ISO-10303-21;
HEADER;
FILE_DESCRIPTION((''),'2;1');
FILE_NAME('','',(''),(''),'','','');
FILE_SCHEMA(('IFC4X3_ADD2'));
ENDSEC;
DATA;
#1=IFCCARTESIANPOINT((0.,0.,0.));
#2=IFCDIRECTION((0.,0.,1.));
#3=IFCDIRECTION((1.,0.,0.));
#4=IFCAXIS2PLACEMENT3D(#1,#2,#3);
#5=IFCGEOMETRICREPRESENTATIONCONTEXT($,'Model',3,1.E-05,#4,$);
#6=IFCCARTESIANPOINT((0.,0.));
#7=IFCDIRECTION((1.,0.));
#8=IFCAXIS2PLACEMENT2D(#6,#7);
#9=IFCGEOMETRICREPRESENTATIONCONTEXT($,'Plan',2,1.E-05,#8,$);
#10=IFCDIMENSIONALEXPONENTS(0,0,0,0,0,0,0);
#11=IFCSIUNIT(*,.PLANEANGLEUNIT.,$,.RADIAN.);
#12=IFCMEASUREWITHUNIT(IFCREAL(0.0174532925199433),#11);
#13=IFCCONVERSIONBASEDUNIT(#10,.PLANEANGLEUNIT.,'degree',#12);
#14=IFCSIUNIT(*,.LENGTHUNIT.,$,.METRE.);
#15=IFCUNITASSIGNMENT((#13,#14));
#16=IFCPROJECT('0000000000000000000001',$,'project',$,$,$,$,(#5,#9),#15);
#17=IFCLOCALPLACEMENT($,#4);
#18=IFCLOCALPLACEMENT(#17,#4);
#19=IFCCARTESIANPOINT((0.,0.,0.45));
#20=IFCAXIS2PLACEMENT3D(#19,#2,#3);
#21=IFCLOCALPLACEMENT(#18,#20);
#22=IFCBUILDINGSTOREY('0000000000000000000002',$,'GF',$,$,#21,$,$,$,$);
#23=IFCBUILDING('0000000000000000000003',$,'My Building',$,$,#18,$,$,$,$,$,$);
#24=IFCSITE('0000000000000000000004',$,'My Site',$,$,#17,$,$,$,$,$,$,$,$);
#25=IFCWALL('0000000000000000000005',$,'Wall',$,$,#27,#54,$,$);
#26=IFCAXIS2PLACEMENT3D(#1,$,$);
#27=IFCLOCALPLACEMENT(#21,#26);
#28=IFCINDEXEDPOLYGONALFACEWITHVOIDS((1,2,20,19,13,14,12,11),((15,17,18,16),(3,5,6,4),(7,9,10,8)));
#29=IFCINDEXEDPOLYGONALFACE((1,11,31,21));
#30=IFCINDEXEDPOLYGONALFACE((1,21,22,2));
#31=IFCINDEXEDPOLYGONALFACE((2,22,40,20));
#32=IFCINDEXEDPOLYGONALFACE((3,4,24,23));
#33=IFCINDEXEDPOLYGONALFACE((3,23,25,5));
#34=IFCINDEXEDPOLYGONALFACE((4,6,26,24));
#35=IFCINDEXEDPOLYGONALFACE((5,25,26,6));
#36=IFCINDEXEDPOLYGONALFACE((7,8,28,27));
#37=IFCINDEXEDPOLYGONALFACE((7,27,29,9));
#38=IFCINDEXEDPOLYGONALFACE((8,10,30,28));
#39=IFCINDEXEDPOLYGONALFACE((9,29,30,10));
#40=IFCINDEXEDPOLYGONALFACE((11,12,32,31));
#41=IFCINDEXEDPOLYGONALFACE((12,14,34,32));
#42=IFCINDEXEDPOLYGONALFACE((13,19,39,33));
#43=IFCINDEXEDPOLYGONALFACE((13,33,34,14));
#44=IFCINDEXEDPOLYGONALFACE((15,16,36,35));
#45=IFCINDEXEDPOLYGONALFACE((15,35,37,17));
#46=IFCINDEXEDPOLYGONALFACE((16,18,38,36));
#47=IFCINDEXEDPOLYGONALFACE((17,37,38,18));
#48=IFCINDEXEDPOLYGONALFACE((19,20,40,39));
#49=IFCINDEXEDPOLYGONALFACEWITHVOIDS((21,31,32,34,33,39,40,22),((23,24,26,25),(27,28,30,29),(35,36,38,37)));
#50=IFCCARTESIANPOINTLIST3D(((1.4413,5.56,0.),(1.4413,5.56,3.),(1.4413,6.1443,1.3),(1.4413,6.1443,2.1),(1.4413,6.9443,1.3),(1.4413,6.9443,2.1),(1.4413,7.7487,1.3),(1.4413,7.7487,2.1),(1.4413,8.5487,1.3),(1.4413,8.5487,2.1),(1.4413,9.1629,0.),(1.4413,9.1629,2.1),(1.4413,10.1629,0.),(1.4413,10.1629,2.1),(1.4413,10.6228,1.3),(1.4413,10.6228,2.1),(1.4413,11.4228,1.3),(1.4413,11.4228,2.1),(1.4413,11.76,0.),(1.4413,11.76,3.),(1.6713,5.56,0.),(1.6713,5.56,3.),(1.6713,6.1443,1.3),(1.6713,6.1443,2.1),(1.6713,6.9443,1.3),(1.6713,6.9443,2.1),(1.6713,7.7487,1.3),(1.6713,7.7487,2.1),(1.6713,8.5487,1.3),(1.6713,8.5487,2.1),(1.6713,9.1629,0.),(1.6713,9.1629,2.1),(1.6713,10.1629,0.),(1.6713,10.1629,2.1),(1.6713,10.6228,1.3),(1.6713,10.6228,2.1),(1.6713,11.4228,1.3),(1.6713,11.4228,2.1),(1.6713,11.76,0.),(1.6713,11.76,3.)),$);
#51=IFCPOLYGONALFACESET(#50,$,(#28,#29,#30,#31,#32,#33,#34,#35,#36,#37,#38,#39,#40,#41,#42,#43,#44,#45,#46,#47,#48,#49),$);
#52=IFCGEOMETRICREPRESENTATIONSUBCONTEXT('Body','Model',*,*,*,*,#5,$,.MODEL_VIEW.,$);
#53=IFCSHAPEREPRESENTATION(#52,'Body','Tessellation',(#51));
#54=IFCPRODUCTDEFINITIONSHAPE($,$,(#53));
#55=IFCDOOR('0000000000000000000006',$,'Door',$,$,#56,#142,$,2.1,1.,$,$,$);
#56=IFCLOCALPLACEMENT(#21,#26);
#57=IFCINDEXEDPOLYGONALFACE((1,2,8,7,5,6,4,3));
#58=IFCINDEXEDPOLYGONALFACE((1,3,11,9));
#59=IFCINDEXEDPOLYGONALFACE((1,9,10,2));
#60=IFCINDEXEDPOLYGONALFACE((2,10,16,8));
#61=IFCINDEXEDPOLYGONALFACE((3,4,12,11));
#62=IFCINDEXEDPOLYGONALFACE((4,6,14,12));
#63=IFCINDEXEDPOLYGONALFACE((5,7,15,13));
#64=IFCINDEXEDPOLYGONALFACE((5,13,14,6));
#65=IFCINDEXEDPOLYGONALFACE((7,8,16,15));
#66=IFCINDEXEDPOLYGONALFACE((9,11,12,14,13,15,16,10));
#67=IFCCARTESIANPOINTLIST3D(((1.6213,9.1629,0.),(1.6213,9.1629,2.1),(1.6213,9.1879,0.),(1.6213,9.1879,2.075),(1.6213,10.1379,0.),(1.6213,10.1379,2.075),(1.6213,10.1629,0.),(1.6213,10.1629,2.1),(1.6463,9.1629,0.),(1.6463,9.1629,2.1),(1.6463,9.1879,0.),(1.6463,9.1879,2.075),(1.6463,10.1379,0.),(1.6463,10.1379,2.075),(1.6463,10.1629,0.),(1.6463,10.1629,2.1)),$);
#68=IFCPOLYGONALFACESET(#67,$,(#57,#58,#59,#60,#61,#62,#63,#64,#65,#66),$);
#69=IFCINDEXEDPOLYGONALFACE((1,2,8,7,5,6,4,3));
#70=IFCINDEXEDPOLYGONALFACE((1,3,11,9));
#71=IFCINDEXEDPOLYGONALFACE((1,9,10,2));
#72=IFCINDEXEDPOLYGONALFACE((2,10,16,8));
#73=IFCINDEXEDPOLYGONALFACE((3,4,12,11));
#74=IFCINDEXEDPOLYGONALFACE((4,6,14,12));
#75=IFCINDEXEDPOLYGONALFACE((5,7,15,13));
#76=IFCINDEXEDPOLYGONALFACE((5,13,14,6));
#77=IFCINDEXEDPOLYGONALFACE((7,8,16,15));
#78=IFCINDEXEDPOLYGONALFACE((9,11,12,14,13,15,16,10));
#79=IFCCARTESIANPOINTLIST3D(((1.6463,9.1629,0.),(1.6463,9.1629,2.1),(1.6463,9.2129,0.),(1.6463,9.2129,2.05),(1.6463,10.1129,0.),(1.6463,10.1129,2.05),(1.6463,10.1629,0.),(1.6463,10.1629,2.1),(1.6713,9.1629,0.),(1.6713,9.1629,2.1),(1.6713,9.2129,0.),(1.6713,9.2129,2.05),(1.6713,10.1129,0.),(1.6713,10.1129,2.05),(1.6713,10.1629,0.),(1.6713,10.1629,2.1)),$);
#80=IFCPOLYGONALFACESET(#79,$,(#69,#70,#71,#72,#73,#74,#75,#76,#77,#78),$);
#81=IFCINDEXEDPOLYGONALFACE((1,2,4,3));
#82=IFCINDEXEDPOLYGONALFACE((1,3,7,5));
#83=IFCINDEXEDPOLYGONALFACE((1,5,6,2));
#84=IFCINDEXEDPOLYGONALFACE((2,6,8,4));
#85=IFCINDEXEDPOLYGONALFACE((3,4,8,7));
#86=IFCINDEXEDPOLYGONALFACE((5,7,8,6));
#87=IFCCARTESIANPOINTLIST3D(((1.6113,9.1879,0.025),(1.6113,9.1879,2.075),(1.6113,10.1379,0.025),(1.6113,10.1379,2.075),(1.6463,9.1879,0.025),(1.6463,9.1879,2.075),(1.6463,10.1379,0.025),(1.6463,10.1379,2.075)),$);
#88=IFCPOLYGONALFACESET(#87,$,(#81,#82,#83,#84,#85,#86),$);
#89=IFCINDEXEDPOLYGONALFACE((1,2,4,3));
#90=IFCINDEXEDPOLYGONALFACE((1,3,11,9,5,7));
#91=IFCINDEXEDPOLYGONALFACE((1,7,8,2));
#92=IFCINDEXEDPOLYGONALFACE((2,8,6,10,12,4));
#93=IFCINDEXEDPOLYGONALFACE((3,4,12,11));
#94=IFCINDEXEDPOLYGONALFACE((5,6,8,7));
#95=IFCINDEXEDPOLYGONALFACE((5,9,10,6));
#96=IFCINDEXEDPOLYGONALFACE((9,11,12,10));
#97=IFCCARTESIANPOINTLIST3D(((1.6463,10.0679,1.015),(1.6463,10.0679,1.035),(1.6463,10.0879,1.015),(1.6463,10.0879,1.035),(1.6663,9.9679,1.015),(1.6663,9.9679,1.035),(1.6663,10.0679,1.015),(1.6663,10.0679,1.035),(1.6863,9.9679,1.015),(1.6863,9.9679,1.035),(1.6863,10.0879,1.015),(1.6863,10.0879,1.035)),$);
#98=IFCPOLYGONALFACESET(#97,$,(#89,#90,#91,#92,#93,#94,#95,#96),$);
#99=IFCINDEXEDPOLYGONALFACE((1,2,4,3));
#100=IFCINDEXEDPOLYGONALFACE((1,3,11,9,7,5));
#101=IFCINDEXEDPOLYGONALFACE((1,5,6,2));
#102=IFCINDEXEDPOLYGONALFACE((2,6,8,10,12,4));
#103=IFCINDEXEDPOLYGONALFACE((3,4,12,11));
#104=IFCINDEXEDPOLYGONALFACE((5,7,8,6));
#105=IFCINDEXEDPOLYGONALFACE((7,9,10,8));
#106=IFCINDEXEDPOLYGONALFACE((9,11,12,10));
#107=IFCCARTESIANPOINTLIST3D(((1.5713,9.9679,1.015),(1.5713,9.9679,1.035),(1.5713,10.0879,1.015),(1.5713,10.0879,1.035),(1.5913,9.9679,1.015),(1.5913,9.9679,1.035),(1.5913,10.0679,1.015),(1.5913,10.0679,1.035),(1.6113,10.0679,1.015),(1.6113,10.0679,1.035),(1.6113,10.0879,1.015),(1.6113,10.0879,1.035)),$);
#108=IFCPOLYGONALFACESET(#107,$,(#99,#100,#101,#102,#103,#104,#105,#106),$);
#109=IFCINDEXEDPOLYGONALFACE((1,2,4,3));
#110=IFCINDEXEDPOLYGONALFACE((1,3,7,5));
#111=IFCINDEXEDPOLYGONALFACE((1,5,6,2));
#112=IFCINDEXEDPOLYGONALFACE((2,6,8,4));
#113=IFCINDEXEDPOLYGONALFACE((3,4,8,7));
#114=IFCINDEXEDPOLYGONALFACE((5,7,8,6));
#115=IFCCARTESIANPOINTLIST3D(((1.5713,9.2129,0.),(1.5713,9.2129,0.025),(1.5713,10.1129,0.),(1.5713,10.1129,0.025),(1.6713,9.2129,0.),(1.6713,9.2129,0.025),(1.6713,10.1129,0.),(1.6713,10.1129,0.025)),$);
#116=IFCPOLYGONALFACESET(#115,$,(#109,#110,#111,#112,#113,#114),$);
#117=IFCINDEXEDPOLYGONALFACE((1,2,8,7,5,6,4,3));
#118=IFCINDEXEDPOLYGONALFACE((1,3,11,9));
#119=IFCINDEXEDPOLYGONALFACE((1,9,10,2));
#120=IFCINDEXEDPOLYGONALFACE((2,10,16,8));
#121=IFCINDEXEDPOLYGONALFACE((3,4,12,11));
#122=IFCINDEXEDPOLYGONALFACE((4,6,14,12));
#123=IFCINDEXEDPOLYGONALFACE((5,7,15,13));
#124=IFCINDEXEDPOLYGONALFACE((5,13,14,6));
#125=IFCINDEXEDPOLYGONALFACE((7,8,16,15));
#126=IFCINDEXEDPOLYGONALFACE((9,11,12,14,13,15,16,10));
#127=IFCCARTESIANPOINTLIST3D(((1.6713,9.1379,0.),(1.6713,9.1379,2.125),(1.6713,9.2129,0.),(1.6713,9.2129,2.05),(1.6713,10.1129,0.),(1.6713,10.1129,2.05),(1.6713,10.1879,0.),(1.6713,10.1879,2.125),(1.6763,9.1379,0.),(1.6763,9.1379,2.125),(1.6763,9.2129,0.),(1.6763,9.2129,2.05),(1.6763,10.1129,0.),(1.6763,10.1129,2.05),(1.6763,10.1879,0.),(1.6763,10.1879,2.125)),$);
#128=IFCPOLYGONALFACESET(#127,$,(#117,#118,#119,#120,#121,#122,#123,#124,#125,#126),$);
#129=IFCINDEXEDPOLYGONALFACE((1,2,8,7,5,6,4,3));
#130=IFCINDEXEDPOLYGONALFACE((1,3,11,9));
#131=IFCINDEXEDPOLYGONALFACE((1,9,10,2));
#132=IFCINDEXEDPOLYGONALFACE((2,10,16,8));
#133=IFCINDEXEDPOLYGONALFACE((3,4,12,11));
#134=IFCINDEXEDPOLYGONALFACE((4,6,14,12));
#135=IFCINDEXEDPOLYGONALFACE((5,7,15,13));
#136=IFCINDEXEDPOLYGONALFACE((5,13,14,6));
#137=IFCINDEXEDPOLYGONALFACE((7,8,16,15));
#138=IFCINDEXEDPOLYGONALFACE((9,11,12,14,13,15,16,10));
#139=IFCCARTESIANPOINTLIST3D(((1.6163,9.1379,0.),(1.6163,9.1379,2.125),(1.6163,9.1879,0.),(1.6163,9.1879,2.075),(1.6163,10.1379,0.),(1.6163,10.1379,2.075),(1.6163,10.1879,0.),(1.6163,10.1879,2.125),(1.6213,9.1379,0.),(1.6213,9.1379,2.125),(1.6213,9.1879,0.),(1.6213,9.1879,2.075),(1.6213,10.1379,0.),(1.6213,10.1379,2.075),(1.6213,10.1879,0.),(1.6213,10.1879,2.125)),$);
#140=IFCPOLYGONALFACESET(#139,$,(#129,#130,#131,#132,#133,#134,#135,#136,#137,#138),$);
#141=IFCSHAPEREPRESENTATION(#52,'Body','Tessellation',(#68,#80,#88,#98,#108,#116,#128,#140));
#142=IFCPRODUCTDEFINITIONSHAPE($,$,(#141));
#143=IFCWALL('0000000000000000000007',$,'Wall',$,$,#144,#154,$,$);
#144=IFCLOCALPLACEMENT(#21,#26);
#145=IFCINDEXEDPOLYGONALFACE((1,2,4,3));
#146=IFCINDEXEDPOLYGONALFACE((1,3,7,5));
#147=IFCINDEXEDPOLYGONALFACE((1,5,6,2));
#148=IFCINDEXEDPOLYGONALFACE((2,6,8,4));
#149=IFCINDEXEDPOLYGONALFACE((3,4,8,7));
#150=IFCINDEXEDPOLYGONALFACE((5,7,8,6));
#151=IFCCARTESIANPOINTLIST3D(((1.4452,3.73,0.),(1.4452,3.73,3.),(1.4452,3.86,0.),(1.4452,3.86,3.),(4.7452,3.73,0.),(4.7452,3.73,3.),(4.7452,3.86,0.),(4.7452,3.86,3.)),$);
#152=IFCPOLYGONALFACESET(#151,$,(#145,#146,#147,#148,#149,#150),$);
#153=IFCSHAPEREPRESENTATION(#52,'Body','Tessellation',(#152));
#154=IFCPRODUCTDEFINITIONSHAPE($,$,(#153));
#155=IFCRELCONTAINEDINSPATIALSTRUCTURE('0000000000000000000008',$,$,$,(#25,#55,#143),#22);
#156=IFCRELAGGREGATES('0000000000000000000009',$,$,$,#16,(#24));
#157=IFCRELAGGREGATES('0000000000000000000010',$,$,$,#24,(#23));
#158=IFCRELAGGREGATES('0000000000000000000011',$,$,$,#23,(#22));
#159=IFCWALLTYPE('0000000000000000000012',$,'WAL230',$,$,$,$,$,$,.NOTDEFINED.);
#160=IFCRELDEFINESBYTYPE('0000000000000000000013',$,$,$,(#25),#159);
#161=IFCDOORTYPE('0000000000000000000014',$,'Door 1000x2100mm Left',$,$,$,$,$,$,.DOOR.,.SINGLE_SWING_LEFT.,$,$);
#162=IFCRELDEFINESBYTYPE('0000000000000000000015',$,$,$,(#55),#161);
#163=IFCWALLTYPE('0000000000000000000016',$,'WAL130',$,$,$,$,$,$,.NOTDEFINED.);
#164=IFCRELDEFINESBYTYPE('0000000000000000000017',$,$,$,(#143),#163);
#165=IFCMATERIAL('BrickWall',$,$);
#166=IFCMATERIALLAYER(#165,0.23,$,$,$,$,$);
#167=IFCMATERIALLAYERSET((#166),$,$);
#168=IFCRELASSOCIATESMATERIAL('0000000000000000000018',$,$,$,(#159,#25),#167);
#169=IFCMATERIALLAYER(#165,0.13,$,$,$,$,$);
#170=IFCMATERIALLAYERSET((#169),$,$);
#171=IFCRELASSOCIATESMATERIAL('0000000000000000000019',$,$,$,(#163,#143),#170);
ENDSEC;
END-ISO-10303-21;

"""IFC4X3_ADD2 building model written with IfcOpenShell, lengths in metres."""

from ifc_helpers import new_model, entity, si_unit, converted_unit, frame, origin_with_axes, origin_2d_with_axis, place, context, subcontext, project, spatial, line, indexed_curve, outline, extrude, shape, source, transform, mapped, material, layer, layer_set, layer_usage, type_object, type_shapes, element, fill, save


model = new_model("IFC4X3_ADD2")

# Units and contexts
model_context = context("Model", 3, precision=1e-05, world=origin_with_axes())
plan_context = context("Plan", 2, precision=1e-05, world=origin_2d_with_axis())
body_context_1 = subcontext(model_context, "Body", "Model", "MODEL_VIEW")
body_context_2 = subcontext(plan_context, "Body", "Plan", "PLAN_VIEW")
ifc_project = project(units=[converted_unit("PLANEANGLEUNIT", "degree", entity("IfcReal", 0.0174532925199433), si_unit("PLANEANGLEUNIT", "RADIAN"), dimensions=[0, 0, 0, 0, 0, 0, 0]), si_unit("LENGTHUNIT", "METRE")], contexts=[model_context, plan_context])

# Site, building, storey
site_placement = place(None, origin_with_axes())
site = spatial("IfcSite", under=ifc_project, at=site_placement, Name="My Site")
building_placement = place(site_placement, origin_with_axes())
building = spatial("IfcBuilding", under=site, at=building_placement, Name="My Building")
storey_placement = place(building_placement, frame((0.0, 0.0, 0.45), z_axis=(0.0, 0.0, 1.0), x_axis=(1.0, 0.0, 0.0)))
storey = spatial("IfcBuildingStorey", under=building, at=storey_placement, Name="GF")

# Shared definitions
ifc_material_1 = material(Name="BrickWall")

# Shared definitions
ifc_layer_1 = layer(ifc_material_1, 0.23)
ifc_layer_set_1 = layer_set([ifc_layer_1])
wall_type_1 = type_object("IfcWallType", Name="WAL230", PredefinedType="NOTDEFINED", material=ifc_layer_set_1)

# Wall, openings, door
ifc_layer_usage_1 = layer_usage(ifc_layer_set_1, "AXIS2", "POSITIVE", 0.0)
wall_1_placement = place(storey_placement, frame((1.6713, 5.56, 0.0), z_axis=(0.0, 0.0, 1.0), x_axis=(0.0, 1.0, 0.0)))
wall_1 = element("IfcWall", 1, at=wall_1_placement, inside=storey, type_object=wall_type_1, material=ifc_layer_usage_1, Name="Wall", context=body_context_1, shape_type="SweptSolid", body=[
    extrude(outline(indexed_curve([(0.0, 0.0), (0.0, 0.23), (6.2, 0.23), (6.2, 0.0), (0.0, 0.0)], self_intersect=False)), origin_with_axes(), (0.0, 0.0, 1.0), 3.0),
])
shared_shape_1 = source(origin_with_axes(), body_context_1, "Body", "SweptSolid", [
    extrude(outline(indexed_curve([(0.0, 0.0), (1.0, 0.0), (1.0, 2.1), (0.0, 2.1)], segments=[line(1, 2, 3, 4, 1)])), frame((0.0, -0.6, 0.0), z_axis=(0.0, -1.0, 0.0), x_axis=(1.0, 0.0, 0.0)), (0.0, 0.0, -1.0), 1.2),
])
opening_1_placement = place(wall_1_placement, frame((3.6029, 0.0, 0.0), z_axis=(0.0, 0.0, 1.0), x_axis=(1.0, 0.0, 0.0)))
opening_1 = element("IfcOpeningElement", 2, at=opening_1_placement, cuts=wall_1, PredefinedType="OPENING", context=body_context_1, shape_type="MappedRepresentation", body=[
    mapped(shared_shape_1, transform((0.0, 0.0, 0.0), x_axis=(1.0, 0.0, 0.0), y_axis=(0.0, 1.0, 0.0), z_axis=(0.0, 0.0, 1.0), scale=1.0)),
])
shared_shape_2 = source(origin_with_axes(), body_context_1, "Body", "SweptSolid", [
    extrude(outline(indexed_curve([(0.0, 0.0), (0.8, 0.0), (0.8, 0.8), (0.0, 0.8)], segments=[line(1, 2, 3, 4, 1)])), frame((-0.4, -0.6, 0.0), z_axis=(0.0, -1.0, 0.0), x_axis=(1.0, 0.0, 0.0)), (0.0, 0.0, -1.0), 1.2),
])
opening_2_placement = place(wall_1_placement, frame((2.5887, 0.0, 1.3), z_axis=(0.0, 0.0, 1.0), x_axis=(1.0, 0.0, 0.0)))
element("IfcOpeningElement", 3, at=opening_2_placement, cuts=wall_1, PredefinedType="OPENING", context=body_context_1, shape_type="MappedRepresentation", body=[
    mapped(shared_shape_2, transform((0.0, 0.0, 0.0), x_axis=(1.0, 0.0, 0.0), y_axis=(0.0, 1.0, 0.0), z_axis=(0.0, 0.0, 1.0), scale=1.0)),
])
opening_3_placement = place(wall_1_placement, frame((0.9843, 0.0, 1.3), z_axis=(0.0, 0.0, 1.0), x_axis=(1.0, 0.0, 0.0)))
element("IfcOpeningElement", 4, at=opening_3_placement, cuts=wall_1, PredefinedType="OPENING", context=body_context_1, shape_type="MappedRepresentation", body=[
    mapped(shared_shape_2, transform((0.0, 0.0, 0.0), x_axis=(1.0, 0.0, 0.0), y_axis=(0.0, 1.0, 0.0), z_axis=(0.0, 0.0, 1.0), scale=1.0)),
])
opening_4_placement = place(wall_1_placement, frame((5.4628, 0.0, 1.3), z_axis=(0.0, 0.0, 1.0), x_axis=(1.0, 0.0, 0.0)))
element("IfcOpeningElement", 5, at=opening_4_placement, cuts=wall_1, PredefinedType="OPENING", context=body_context_1, shape_type="MappedRepresentation", body=[
    mapped(shared_shape_2, transform((0.0, 0.0, 0.0), x_axis=(1.0, 0.0, 0.0), y_axis=(0.0, 1.0, 0.0), z_axis=(0.0, 0.0, 1.0), scale=1.0)),
])
door_type_1 = type_object("IfcDoorType", Name="Door 1000x2100mm Left", OperationType="SINGLE_SWING_LEFT", PredefinedType="DOOR")
shared_shape_3 = source(origin_with_axes(), body_context_1, "Body", "SweptSolid", [
    extrude(outline(indexed_curve([(0.0, 0.0), (0.0, 2.1), (1.0, 2.1), (1.0, 0.0), (0.975, 0.0), (0.975, 2.075), (0.025, 2.075), (0.025, 0.0)], segments=[line(1, 2, 3, 4, 5, 6, 7, 8, 1)])), frame((0.0, 0.025, 0.0), z_axis=(0.0, -1.0, 0.0), x_axis=(1.0, 0.0, 0.0)), (0.0, 0.0, -1.0), 0.025),
    extrude(outline(indexed_curve([(0.0, 0.0), (0.0, 2.1), (1.0, 2.1), (1.0, 0.0), (0.95, 0.0), (0.95, 2.05), (0.05, 2.05), (0.05, 0.0)], segments=[line(1, 2, 3, 4, 5, 6, 7, 8, 1)])), frame((0.0, 0.0, 0.0), z_axis=(0.0, -1.0, 0.0), x_axis=(1.0, 0.0, 0.0)), (0.0, 0.0, -1.0), 0.025),
    extrude(outline(indexed_curve([(0.0, 0.0), (0.95, 0.0), (0.95, 0.035), (0.0, 0.035)], segments=[line(1, 2, 3, 4, 1)])), frame((0.025, 0.025, 0.025), z_axis=(0.0, 0.0, 1.0), x_axis=(1.0, 0.0, 0.0)), (0.0, 0.0, 1.0), 2.05),
    extrude(outline(indexed_curve([(0.0, 0.0), (0.0, -0.04), (-0.12, -0.04), (-0.12, -0.02), (-0.02, -0.02), (-0.02, 0.0)], segments=[line(1, 2, 3, 4, 5, 6, 1)])), frame((0.925, 0.025, 1.015), z_axis=(0.0, 0.0, 1.0), x_axis=(1.0, 0.0, 0.0)), (0.0, 0.0, 1.0), 0.02),
    extrude(outline(indexed_curve([(0.0, 0.0), (0.0, 0.04), (-0.12, 0.04), (-0.12, 0.02), (-0.02, 0.02), (-0.02, 0.0)], segments=[line(1, 2, 3, 4, 5, 6, 1)])), frame((0.925, 0.06, 1.015), z_axis=(0.0, 0.0, 1.0), x_axis=(1.0, 0.0, 0.0)), (0.0, 0.0, 1.0), 0.02),
    extrude(outline(indexed_curve([(0.0, 0.0), (0.9, 0.0), (0.9, 0.1), (0.0, 0.1)], segments=[line(1, 2, 3, 4, 1)])), frame((0.05, 0.0, 0.0), z_axis=(0.0, 0.0, 1.0), x_axis=(1.0, 0.0, 0.0)), (0.0, 0.0, 1.0), 0.025),
    extrude(outline(indexed_curve([(0.0, 0.0), (0.0, 2.125), (1.05, 2.125), (1.05, 0.0), (0.975, 0.0), (0.975, 2.05), (0.075, 2.05), (0.075, 0.0)], segments=[line(1, 2, 3, 4, 5, 6, 7, 8, 1)])), frame((-0.025, -0.005, 0.0), z_axis=(0.0, -1.0, 0.0), x_axis=(1.0, 0.0, 0.0)), (0.0, 0.0, -1.0), 0.005),
    extrude(outline(indexed_curve([(0.0, 0.0), (0.0, 2.125), (1.05, 2.125), (1.05, 0.0), (1.0, 0.0), (1.0, 2.075), (0.05, 2.075), (0.05, 0.0)], segments=[line(1, 2, 3, 4, 5, 6, 7, 8, 1)])), frame((-0.025, 0.05, 0.0), z_axis=(0.0, -1.0, 0.0), x_axis=(1.0, 0.0, 0.0)), (0.0, 0.0, -1.0), 0.005),
])
shared_shape_4 = source(origin_with_axes(), body_context_2, "Body", "Curve2D", [
    entity("IfcIndexedPolyCurve", entity("IfcCartesianPointList2D", [[0.0, 0.0], [0.0, 0.05], [0.025, 0.05], [0.025, 0.025], [0.05, 0.025], [0.05, 0.0]]), [entity("IfcLineIndex", [1, 2, 3, 4, 5, 6, 1])]),
    entity("IfcIndexedPolyCurve", entity("IfcCartesianPointList2D", [[1.0, 0.0], [1.0, 0.05], [0.975, 0.05], [0.975, 0.025], [0.95, 0.025], [0.95, 0.0]]), [entity("IfcLineIndex", [1, 2, 3, 4, 5, 6, 1])]),
    entity("IfcTrimmedCurve", entity("IfcEllipse", entity("IfcAxis2Placement2D", entity("IfcCartesianPoint", [0.06, 0.05]), entity("IfcDirection", [1.0, 0.0])), 0.915, 0.95), [entity("IfcCartesianPoint", [0.975, 0.05])], [entity("IfcCartesianPoint", [0.06, 1.0])], True, "CARTESIAN"),
    entity("IfcIndexedPolyCurve", entity("IfcCartesianPointList2D", [[0.025, 0.05], [0.06, 0.05], [0.06, 1.0], [0.025, 1.0]]), [entity("IfcLineIndex", [1, 2, 3, 4, 1])]),
])
type_shapes(door_type_1, [shared_shape_3, shared_shape_4])
door_1_placement = place(opening_1_placement, frame((0.0, 0.0, 0.0), z_axis=(0.0, 0.0, 1.0), x_axis=(1.0, 0.0, 0.0)))
door_1 = element("IfcDoor", 6, at=door_1_placement, inside=storey, type_object=door_type_1, Name="Door", OverallHeight=2.1, OverallWidth=1.0, shapes=[
    shape(body_context_1, "Body", "MappedRepresentation", [mapped(shared_shape_3, transform((0.0, 0.0, 0.0), x_axis=(1.0, 0.0, 0.0), y_axis=(0.0, 1.0, 0.0), z_axis=(0.0, 0.0, 1.0), scale=1.0))]),
    shape(body_context_2, "Body", "MappedRepresentation", [mapped(shared_shape_4, transform((0.0, 0.0, 0.0), x_axis=(1.0, 0.0, 0.0), y_axis=(0.0, 1.0, 0.0), z_axis=(0.0, 0.0, 1.0), scale=1.0))]),
])
fill(opening_1, door_1)

# Wall
ifc_layer_2 = layer(ifc_material_1, 0.13)
ifc_layer_set_2 = layer_set([ifc_layer_2])
ifc_layer_usage_2 = layer_usage(ifc_layer_set_2, "AXIS2", "POSITIVE", 0.0)
wall_type_2 = type_object("IfcWallType", Name="WAL130", PredefinedType="NOTDEFINED", material=ifc_layer_set_2)
wall_2_placement = place(storey_placement, frame((1.4452, 3.73, 0.0), z_axis=(0.0, 0.0, 1.0), x_axis=(1.0, 0.0, 0.0)))
element("IfcWall", 7, at=wall_2_placement, inside=storey, type_object=wall_type_2, material=ifc_layer_usage_2, Name="Wall", context=body_context_1, shape_type="SweptSolid", body=[
    extrude(outline(indexed_curve([(0.0, 0.0), (0.0, 0.13), (3.3, 0.13), (3.3, 0.0), (0.0, 0.0)], self_intersect=False)), origin_with_axes(), (0.0, 0.0, 1.0), 3.0),
])

save(model, "model.ifc")
